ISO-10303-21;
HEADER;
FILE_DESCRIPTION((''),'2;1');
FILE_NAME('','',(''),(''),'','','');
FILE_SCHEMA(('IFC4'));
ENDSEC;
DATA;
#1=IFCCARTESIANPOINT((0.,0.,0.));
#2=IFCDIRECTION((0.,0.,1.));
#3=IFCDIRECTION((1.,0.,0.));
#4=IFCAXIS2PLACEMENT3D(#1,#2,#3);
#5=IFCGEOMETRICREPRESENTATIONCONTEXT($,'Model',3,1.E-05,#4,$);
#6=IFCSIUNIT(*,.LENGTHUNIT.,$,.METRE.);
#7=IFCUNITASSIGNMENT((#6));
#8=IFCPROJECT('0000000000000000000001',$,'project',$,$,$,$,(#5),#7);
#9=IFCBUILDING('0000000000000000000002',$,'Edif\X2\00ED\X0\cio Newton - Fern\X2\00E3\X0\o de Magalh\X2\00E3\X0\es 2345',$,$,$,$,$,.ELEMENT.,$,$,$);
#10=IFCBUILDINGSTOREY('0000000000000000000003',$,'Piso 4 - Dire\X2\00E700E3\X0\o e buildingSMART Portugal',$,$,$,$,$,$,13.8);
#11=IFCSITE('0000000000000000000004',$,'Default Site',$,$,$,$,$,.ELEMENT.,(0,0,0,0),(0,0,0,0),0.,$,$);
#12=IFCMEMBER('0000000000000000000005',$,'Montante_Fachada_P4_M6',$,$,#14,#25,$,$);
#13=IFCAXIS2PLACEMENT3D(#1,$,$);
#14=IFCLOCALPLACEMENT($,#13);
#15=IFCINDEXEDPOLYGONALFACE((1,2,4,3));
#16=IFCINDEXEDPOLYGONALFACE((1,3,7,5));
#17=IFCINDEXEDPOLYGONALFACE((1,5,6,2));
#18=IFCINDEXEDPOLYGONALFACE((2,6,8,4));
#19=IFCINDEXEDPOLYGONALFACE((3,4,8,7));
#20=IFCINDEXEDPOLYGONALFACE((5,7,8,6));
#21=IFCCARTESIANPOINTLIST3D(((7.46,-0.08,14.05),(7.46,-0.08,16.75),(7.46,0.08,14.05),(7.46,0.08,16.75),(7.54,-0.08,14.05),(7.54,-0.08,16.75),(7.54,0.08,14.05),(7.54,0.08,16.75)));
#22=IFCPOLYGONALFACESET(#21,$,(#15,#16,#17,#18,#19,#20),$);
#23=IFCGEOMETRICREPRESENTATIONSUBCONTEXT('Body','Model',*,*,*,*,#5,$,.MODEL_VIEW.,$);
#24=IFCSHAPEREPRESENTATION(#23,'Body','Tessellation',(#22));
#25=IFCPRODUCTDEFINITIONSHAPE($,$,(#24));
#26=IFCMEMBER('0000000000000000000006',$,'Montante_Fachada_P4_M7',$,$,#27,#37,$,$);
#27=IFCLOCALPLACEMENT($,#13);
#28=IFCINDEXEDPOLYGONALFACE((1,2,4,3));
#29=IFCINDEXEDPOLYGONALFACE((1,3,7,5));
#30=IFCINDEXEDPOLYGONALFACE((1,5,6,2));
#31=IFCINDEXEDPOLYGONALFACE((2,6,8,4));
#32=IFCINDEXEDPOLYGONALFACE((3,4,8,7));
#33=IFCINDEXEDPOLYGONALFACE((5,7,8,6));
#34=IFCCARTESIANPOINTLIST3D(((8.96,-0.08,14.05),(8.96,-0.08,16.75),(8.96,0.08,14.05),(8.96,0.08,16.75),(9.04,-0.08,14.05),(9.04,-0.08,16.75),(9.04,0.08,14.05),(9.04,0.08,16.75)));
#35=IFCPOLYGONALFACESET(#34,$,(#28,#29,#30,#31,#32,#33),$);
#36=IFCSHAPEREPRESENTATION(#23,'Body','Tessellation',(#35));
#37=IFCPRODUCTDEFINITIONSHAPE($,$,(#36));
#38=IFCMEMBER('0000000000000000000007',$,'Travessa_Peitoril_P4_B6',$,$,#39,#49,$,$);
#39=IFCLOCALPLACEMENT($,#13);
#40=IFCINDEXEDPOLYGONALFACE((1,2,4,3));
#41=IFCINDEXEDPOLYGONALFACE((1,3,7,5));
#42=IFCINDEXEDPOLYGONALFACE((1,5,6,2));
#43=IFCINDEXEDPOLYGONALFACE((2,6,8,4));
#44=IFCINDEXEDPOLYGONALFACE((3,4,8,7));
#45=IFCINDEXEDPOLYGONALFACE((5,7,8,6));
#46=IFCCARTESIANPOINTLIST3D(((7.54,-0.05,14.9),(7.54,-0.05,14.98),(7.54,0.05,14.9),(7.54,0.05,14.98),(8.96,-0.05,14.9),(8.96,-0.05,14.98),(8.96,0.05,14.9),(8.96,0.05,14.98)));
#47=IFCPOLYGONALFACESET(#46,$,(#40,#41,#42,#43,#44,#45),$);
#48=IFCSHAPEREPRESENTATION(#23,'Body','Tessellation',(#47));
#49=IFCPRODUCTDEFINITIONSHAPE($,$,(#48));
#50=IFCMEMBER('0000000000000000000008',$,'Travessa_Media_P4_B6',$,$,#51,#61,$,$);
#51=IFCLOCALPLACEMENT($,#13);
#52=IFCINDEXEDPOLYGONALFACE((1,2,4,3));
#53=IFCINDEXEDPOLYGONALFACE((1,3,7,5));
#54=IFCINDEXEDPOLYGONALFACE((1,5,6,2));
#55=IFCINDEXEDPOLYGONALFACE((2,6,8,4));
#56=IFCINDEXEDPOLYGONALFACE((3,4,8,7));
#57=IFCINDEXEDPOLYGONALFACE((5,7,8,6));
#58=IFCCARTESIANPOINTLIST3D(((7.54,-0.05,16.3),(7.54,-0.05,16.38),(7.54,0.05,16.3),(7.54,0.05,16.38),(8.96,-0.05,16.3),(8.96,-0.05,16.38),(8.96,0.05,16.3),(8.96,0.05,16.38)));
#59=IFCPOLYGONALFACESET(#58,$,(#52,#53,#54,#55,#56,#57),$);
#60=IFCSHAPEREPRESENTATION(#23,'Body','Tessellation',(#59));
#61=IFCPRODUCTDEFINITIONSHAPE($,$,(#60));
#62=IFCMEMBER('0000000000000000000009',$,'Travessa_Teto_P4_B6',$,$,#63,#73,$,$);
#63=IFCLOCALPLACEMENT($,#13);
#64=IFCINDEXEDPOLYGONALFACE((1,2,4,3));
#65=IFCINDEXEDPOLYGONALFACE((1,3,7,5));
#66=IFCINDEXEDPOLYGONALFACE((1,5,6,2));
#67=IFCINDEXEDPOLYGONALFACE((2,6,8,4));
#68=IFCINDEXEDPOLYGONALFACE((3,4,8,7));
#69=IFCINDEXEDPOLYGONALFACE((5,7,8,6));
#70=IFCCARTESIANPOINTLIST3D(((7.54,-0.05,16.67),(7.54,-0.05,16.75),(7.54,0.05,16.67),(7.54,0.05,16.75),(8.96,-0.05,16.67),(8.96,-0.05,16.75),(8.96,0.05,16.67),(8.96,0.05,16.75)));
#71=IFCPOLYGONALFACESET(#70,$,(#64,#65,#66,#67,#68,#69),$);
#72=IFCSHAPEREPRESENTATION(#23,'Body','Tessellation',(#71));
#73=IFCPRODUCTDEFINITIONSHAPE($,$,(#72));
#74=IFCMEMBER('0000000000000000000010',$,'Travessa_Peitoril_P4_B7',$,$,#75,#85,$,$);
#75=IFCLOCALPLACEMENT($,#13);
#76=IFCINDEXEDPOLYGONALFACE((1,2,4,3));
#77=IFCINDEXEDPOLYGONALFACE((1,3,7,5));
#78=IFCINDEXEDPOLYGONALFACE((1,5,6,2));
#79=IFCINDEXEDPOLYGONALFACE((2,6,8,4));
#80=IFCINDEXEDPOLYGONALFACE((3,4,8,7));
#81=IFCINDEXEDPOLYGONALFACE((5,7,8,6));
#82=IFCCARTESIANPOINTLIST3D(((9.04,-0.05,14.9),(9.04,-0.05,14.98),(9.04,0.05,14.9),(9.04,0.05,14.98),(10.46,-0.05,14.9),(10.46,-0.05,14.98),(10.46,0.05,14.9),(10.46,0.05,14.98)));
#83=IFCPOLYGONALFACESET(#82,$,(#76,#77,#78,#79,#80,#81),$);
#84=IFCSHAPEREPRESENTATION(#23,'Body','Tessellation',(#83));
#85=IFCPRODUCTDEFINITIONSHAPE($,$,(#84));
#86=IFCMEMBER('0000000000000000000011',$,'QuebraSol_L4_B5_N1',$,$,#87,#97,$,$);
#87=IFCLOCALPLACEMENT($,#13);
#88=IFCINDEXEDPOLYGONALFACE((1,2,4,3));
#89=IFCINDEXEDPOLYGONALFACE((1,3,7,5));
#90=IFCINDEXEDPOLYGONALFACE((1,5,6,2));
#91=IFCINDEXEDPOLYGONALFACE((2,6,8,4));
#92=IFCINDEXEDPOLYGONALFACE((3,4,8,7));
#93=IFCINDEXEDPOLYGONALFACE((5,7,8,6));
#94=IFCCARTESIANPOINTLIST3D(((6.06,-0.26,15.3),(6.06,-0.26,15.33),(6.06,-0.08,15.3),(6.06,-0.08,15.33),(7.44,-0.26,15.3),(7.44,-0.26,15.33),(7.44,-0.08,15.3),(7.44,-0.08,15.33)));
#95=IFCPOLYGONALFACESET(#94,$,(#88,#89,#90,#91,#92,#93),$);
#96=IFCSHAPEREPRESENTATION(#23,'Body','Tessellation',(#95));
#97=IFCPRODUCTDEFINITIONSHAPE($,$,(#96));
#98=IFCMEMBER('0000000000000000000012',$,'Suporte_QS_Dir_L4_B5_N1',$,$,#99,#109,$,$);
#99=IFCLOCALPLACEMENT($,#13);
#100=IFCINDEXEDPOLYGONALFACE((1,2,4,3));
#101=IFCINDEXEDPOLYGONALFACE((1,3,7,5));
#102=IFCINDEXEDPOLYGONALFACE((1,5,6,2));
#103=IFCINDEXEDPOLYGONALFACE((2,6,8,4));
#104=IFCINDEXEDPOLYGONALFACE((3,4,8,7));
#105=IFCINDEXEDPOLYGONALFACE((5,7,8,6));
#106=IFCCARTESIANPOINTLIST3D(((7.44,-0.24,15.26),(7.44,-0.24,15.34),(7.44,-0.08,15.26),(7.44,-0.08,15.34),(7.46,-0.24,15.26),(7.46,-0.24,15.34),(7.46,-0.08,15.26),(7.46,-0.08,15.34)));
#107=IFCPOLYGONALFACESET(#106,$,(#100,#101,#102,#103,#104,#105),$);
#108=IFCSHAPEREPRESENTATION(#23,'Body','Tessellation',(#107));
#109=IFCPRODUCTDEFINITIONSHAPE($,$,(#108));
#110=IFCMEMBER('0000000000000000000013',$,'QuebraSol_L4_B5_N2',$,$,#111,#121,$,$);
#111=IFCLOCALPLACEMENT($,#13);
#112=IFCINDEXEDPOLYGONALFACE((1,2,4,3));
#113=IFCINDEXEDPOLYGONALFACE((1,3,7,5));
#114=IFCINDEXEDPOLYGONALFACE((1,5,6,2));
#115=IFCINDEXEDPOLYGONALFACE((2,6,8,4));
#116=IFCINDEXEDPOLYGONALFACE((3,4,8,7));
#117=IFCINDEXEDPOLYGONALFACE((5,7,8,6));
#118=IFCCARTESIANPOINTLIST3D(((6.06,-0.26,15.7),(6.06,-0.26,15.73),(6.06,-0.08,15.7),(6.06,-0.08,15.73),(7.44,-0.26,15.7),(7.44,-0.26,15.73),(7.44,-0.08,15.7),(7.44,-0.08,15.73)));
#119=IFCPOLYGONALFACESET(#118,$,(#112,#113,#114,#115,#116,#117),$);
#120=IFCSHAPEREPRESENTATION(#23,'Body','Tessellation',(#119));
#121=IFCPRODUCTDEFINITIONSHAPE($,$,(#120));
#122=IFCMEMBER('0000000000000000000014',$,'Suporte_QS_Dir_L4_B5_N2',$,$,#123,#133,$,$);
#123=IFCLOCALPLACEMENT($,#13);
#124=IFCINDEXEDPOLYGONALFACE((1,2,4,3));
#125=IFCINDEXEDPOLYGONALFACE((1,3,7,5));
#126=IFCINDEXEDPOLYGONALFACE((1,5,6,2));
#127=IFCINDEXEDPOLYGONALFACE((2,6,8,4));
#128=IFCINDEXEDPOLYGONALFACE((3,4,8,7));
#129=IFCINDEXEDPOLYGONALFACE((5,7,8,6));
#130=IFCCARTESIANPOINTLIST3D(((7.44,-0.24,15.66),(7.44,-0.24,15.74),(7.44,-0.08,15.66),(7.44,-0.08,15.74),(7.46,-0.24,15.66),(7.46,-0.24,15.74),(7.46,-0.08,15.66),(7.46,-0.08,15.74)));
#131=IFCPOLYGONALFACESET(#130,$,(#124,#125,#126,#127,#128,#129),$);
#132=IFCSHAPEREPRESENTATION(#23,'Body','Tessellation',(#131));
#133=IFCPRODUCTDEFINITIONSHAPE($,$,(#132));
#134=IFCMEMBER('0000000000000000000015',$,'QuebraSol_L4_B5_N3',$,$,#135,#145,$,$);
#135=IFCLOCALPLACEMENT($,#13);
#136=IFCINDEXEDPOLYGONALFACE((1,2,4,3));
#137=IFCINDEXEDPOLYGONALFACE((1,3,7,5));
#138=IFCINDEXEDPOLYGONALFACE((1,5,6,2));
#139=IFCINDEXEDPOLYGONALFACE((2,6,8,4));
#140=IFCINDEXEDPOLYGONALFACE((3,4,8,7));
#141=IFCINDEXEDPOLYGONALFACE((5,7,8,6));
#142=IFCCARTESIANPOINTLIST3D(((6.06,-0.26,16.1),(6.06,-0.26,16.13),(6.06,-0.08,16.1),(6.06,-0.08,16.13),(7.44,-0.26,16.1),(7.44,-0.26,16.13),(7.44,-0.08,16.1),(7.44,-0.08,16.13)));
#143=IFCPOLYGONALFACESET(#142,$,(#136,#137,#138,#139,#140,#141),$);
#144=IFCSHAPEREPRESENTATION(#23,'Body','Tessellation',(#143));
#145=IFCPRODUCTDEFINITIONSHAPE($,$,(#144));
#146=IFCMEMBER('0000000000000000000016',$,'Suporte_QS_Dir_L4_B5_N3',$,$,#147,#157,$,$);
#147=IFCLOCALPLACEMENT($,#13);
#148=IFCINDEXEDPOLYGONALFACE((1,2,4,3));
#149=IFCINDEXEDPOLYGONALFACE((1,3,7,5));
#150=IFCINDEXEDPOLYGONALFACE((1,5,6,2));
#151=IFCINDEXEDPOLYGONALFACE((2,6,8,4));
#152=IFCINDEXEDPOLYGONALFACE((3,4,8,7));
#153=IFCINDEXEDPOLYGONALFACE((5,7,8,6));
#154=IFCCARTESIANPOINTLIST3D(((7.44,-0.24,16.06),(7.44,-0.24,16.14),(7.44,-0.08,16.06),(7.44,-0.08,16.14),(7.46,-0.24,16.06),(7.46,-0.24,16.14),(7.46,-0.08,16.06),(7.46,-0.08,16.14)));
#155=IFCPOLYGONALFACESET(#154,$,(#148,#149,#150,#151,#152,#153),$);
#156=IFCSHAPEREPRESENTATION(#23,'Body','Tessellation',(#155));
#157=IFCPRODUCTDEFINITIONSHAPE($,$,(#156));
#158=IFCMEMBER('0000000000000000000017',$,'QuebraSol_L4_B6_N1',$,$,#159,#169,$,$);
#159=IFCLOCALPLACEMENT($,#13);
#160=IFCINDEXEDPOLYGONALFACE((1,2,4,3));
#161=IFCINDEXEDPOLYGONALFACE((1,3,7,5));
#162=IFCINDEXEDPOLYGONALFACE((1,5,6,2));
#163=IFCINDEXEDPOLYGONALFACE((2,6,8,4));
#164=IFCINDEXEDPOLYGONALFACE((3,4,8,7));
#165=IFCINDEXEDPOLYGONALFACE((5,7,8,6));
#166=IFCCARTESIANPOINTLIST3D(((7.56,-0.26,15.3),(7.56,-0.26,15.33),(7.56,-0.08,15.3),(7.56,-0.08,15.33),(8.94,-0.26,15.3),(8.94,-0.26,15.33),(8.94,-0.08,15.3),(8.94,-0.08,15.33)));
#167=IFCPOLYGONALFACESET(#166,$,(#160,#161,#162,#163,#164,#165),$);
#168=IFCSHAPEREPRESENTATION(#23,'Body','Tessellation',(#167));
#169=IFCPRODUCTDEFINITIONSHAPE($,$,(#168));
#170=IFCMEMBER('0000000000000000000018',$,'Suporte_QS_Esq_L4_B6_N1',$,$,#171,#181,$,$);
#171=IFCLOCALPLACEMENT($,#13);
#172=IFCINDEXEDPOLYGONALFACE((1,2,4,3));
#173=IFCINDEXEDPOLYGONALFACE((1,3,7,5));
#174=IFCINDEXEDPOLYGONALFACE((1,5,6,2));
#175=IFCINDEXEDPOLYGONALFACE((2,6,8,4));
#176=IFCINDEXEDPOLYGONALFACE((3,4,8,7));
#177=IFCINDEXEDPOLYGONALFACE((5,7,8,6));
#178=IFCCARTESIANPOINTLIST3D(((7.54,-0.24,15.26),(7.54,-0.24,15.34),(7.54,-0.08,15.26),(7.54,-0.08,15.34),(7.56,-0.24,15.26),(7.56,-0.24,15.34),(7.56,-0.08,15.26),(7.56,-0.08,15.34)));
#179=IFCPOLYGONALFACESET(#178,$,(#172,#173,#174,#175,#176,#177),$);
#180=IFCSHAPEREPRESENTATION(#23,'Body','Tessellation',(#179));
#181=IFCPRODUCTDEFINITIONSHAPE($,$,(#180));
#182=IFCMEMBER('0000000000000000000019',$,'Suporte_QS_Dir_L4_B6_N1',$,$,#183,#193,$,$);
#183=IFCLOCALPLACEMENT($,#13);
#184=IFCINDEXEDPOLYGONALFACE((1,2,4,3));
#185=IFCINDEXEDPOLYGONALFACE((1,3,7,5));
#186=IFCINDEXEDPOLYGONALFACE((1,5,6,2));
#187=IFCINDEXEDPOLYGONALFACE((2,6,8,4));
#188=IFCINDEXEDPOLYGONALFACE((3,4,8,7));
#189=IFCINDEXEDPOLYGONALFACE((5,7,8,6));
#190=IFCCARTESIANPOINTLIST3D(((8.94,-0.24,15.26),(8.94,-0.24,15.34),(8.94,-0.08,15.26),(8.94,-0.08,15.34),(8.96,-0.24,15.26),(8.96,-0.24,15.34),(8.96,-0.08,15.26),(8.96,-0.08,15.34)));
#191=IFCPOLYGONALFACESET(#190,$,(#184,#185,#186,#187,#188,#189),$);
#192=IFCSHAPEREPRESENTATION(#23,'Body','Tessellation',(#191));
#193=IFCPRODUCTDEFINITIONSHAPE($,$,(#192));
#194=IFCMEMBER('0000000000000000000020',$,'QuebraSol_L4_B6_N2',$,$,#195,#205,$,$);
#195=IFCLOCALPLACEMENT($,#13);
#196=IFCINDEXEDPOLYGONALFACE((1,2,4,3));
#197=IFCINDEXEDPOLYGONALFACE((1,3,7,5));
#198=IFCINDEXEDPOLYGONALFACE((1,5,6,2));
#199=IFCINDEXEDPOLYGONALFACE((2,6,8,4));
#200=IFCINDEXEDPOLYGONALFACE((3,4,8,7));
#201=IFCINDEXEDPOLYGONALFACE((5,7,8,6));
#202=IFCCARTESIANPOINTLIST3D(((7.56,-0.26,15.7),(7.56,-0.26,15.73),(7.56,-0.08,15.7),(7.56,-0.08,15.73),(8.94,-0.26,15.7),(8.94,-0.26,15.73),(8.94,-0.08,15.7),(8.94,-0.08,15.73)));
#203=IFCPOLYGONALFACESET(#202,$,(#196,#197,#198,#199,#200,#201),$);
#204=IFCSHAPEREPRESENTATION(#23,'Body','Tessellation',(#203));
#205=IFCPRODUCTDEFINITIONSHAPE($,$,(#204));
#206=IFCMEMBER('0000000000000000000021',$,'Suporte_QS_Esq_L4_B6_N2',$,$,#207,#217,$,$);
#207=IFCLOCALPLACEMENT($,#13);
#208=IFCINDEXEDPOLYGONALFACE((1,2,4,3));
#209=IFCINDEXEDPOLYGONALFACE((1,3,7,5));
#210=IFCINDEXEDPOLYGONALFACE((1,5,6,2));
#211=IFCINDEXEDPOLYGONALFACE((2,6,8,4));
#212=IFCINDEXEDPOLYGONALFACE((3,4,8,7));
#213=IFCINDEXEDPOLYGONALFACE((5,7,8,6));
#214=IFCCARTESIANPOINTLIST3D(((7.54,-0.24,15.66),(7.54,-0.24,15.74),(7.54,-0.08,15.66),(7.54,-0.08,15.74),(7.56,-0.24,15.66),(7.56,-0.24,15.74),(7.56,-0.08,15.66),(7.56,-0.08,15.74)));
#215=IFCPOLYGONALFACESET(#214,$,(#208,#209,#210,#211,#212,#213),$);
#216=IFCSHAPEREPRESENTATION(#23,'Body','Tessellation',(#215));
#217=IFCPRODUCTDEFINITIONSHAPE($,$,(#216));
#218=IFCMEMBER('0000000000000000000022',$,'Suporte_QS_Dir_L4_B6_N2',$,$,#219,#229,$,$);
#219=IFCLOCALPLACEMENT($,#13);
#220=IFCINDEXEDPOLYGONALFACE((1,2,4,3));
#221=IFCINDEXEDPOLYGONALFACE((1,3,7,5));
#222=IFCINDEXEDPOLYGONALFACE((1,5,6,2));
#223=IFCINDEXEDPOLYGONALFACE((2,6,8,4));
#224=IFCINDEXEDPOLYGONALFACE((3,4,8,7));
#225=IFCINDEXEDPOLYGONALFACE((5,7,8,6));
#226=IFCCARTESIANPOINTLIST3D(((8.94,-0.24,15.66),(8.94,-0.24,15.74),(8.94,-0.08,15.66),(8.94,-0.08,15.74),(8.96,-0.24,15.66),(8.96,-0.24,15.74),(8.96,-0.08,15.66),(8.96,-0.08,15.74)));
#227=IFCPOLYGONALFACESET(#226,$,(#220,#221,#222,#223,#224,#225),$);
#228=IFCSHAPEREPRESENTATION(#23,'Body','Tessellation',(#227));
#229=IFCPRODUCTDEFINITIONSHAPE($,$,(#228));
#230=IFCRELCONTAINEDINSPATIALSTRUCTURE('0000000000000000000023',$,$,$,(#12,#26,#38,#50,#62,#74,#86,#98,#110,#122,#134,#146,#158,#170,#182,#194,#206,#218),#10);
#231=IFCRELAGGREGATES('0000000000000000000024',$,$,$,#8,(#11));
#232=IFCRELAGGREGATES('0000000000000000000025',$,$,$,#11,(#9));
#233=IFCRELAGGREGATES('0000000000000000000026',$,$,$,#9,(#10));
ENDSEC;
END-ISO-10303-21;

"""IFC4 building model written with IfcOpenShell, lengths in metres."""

from ifc_helpers import new_model, si_unit, frame, frame_2d, origin_with_axes, place, context, subcontext, project, spatial, rectangle, extrude, element, save


model = new_model("IFC4")

# Units and contexts
model_context = context("Model", 3, precision=1e-05, world=origin_with_axes())
body_context = subcontext(model_context, "Body", "Model", "MODEL_VIEW")
ifc_project = project(units=[si_unit("LENGTHUNIT", "METRE")], contexts=[model_context])

# Site, building, storey
site = spatial("IfcSite", under=ifc_project, Name="Default Site", CompositionType="ELEMENT", RefLatitude=(0, 0, 0, 0), RefLongitude=(0, 0, 0, 0), RefElevation=0.0)
building = spatial("IfcBuilding", under=site, Name="Edifício Newton - Fernão de Magalhães 2345", CompositionType="ELEMENT")
storey = spatial("IfcBuildingStorey", under=building, Name="Piso 4 - Direção e buildingSMART Portugal", Elevation=13.8)

# Members
for number, where, z_axis, x_axis, name in (
    (1, (7.46, -0.08, 14.05), (0.0, 0.0, 1.0), (1.0, 0.0, 0.0), "Montante_Fachada_P4_M6"),
    (2, (8.96, -0.08, 14.05), (0.0, 0.0, 1.0), (1.0, 0.0, 0.0), "Montante_Fachada_P4_M7"),
):
    element("IfcMember", number, at=place(None, frame(where, z_axis=z_axis, x_axis=x_axis)), inside=storey, Name=name, context=body_context, shape_type="SweptSolid", body=[
        extrude(rectangle(XDim=0.08, YDim=0.16, at=frame_2d((0.04, 0.08))), origin_with_axes(), (0.0, 0.0, 1.0), 2.7),
    ])
for number, where, z_axis, x_axis, name in (
    (3, (7.54, -0.05, 14.9), (0.0, 0.0, 1.0), (1.0, 0.0, 0.0), "Travessa_Peitoril_P4_B6"),
    (4, (7.54, -0.05, 16.3), (0.0, 0.0, 1.0), (1.0, 0.0, 0.0), "Travessa_Media_P4_B6"),
    (5, (7.54, -0.05, 16.67), (0.0, 0.0, 1.0), (1.0, 0.0, 0.0), "Travessa_Teto_P4_B6"),
):
    element("IfcMember", number, at=place(None, frame(where, z_axis=z_axis, x_axis=x_axis)), inside=storey, Name=name, context=body_context, shape_type="SweptSolid", body=[
        extrude(rectangle(XDim=1.42, YDim=0.1, at=frame_2d((0.71, 0.05))), origin_with_axes(), (0.0, 0.0, 1.0), 0.08),
    ])
member_1_placement = place(None, frame((9.04, -0.05, 14.9), z_axis=(0.0, 0.0, 1.0), x_axis=(1.0, 0.0, 0.0)))
element("IfcMember", 6, at=member_1_placement, inside=storey, Name="Travessa_Peitoril_P4_B7", context=body_context, shape_type="SweptSolid", body=[
    extrude(rectangle(XDim=1.42, YDim=0.1, at=frame_2d((0.71, 0.05))), origin_with_axes(), (0.0, 0.0, 1.0), 0.08),
])
member_2_placement = place(None, frame((6.06, -0.26, 15.3), z_axis=(0.0, 0.0, 1.0), x_axis=(1.0, 0.0, 0.0)))
element("IfcMember", 7, at=member_2_placement, inside=storey, Name="QuebraSol_L4_B5_N1", context=body_context, shape_type="SweptSolid", body=[
    extrude(rectangle(XDim=1.38, YDim=0.18, at=frame_2d((0.69, 0.09))), origin_with_axes(), (0.0, 0.0, 1.0), 0.03),
])
member_3_placement = place(None, frame((7.44, -0.24, 15.26), z_axis=(0.0, 0.0, 1.0), x_axis=(1.0, 0.0, 0.0)))
element("IfcMember", 8, at=member_3_placement, inside=storey, Name="Suporte_QS_Dir_L4_B5_N1", context=body_context, shape_type="SweptSolid", body=[
    extrude(rectangle(XDim=0.02, YDim=0.16, at=frame_2d((0.01, 0.08))), origin_with_axes(), (0.0, 0.0, 1.0), 0.08),
])
member_4_placement = place(None, frame((6.06, -0.26, 15.7), z_axis=(0.0, 0.0, 1.0), x_axis=(1.0, 0.0, 0.0)))
element("IfcMember", 9, at=member_4_placement, inside=storey, Name="QuebraSol_L4_B5_N2", context=body_context, shape_type="SweptSolid", body=[
    extrude(rectangle(XDim=1.38, YDim=0.18, at=frame_2d((0.69, 0.09))), origin_with_axes(), (0.0, 0.0, 1.0), 0.03),
])
member_5_placement = place(None, frame((7.44, -0.24, 15.66), z_axis=(0.0, 0.0, 1.0), x_axis=(1.0, 0.0, 0.0)))
element("IfcMember", 10, at=member_5_placement, inside=storey, Name="Suporte_QS_Dir_L4_B5_N2", context=body_context, shape_type="SweptSolid", body=[
    extrude(rectangle(XDim=0.02, YDim=0.16, at=frame_2d((0.01, 0.08))), origin_with_axes(), (0.0, 0.0, 1.0), 0.08),
])
member_6_placement = place(None, frame((6.06, -0.26, 16.1), z_axis=(0.0, 0.0, 1.0), x_axis=(1.0, 0.0, 0.0)))
element("IfcMember", 11, at=member_6_placement, inside=storey, Name="QuebraSol_L4_B5_N3", context=body_context, shape_type="SweptSolid", body=[
    extrude(rectangle(XDim=1.38, YDim=0.18, at=frame_2d((0.69, 0.09))), origin_with_axes(), (0.0, 0.0, 1.0), 0.03),
])
member_7_placement = place(None, frame((7.44, -0.24, 16.06), z_axis=(0.0, 0.0, 1.0), x_axis=(1.0, 0.0, 0.0)))
element("IfcMember", 12, at=member_7_placement, inside=storey, Name="Suporte_QS_Dir_L4_B5_N3", context=body_context, shape_type="SweptSolid", body=[
    extrude(rectangle(XDim=0.02, YDim=0.16, at=frame_2d((0.01, 0.08))), origin_with_axes(), (0.0, 0.0, 1.0), 0.08),
])
member_8_placement = place(None, frame((7.56, -0.26, 15.3), z_axis=(0.0, 0.0, 1.0), x_axis=(1.0, 0.0, 0.0)))
element("IfcMember", 13, at=member_8_placement, inside=storey, Name="QuebraSol_L4_B6_N1", context=body_context, shape_type="SweptSolid", body=[
    extrude(rectangle(XDim=1.38, YDim=0.18, at=frame_2d((0.69, 0.09))), origin_with_axes(), (0.0, 0.0, 1.0), 0.03),
])
for number, where, z_axis, x_axis, name in (
    (14, (7.54, -0.24, 15.26), (0.0, 0.0, 1.0), (1.0, 0.0, 0.0), "Suporte_QS_Esq_L4_B6_N1"),
    (15, (8.94, -0.24, 15.26), (0.0, 0.0, 1.0), (1.0, 0.0, 0.0), "Suporte_QS_Dir_L4_B6_N1"),
):
    element("IfcMember", number, at=place(None, frame(where, z_axis=z_axis, x_axis=x_axis)), inside=storey, Name=name, context=body_context, shape_type="SweptSolid", body=[
        extrude(rectangle(XDim=0.02, YDim=0.16, at=frame_2d((0.01, 0.08))), origin_with_axes(), (0.0, 0.0, 1.0), 0.08),
    ])
member_9_placement = place(None, frame((7.56, -0.26, 15.7), z_axis=(0.0, 0.0, 1.0), x_axis=(1.0, 0.0, 0.0)))
element("IfcMember", 16, at=member_9_placement, inside=storey, Name="QuebraSol_L4_B6_N2", context=body_context, shape_type="SweptSolid", body=[
    extrude(rectangle(XDim=1.38, YDim=0.18, at=frame_2d((0.69, 0.09))), origin_with_axes(), (0.0, 0.0, 1.0), 0.03),
])
for number, where, z_axis, x_axis, name in (
    (17, (7.54, -0.24, 15.66), (0.0, 0.0, 1.0), (1.0, 0.0, 0.0), "Suporte_QS_Esq_L4_B6_N2"),
    (18, (8.94, -0.24, 15.66), (0.0, 0.0, 1.0), (1.0, 0.0, 0.0), "Suporte_QS_Dir_L4_B6_N2"),
):
    element("IfcMember", number, at=place(None, frame(where, z_axis=z_axis, x_axis=x_axis)), inside=storey, Name=name, context=body_context, shape_type="SweptSolid", body=[
        extrude(rectangle(XDim=0.02, YDim=0.16, at=frame_2d((0.01, 0.08))), origin_with_axes(), (0.0, 0.0, 1.0), 0.08),
    ])

save(model, "model.ifc")
